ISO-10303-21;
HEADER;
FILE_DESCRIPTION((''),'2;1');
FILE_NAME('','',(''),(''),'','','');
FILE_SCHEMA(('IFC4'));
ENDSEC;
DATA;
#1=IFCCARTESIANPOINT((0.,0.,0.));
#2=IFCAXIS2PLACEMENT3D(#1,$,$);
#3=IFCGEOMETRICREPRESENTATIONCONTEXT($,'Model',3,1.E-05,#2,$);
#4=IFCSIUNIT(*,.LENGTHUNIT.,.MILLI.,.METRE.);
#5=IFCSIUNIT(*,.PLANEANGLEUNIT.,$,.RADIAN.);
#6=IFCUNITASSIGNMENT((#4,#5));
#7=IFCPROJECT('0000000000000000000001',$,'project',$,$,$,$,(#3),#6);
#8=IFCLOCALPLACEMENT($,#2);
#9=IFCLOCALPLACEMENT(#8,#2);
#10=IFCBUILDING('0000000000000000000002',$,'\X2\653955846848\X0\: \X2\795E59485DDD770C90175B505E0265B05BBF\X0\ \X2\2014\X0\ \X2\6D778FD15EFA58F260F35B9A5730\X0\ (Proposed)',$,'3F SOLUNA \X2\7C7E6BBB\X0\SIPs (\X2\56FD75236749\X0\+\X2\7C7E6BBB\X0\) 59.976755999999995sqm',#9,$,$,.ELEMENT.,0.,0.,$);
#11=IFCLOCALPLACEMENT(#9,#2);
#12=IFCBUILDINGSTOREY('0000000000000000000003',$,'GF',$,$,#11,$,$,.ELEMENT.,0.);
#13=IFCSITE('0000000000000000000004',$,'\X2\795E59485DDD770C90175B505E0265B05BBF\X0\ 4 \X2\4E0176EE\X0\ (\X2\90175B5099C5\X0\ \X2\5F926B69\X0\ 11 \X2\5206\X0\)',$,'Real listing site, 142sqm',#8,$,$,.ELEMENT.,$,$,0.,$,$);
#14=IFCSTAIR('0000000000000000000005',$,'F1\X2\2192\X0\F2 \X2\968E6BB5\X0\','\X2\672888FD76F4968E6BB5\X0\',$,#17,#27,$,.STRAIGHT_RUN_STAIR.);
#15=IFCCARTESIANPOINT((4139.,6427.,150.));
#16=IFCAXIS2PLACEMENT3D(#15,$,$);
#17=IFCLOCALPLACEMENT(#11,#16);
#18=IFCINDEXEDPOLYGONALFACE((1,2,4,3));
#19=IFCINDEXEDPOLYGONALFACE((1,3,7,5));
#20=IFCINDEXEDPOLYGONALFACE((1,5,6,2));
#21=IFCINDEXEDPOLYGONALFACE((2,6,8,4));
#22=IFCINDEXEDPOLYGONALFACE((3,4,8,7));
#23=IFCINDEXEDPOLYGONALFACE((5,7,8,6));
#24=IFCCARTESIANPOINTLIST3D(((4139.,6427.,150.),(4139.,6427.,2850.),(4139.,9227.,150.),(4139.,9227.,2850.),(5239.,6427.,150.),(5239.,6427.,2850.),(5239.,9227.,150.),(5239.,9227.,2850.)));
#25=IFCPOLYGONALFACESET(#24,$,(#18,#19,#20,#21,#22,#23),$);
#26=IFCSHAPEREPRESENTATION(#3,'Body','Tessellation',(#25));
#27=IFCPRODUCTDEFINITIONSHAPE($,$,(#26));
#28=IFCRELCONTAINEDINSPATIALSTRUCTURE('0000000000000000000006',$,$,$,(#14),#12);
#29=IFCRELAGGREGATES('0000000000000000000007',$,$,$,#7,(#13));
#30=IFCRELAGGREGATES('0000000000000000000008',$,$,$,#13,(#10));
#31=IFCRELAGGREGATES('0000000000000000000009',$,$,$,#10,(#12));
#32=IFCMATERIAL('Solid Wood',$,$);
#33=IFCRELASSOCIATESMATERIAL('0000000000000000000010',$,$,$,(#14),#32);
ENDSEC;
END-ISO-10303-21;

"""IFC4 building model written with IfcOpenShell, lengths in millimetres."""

from ifc_helpers import new_model, si_unit, frame, frame_2d, origin, place, context, project, spatial, rectangle, extrude, material, element, save


model = new_model("IFC4")

# Units and contexts
model_context = context("Model", 3, precision=1e-05, world=origin())
ifc_project = project(units=[si_unit("LENGTHUNIT", "METRE", prefix="MILLI"), si_unit("PLANEANGLEUNIT", "RADIAN")], contexts=[model_context])

# Site, building, storey
site_placement = place(None, origin())
site = spatial("IfcSite", under=ifc_project, at=site_placement, Name="神奈川県逗子市新宿 4 丁目 (逗子駅 徒歩 11 分)", ObjectType="Real listing site, 142sqm", CompositionType="ELEMENT", RefElevation=0.0)
building_placement = place(site_placement, origin())
building = spatial("IfcBuilding", under=site, at=building_placement, Name="改善案: 神奈川県逗子市新宿 — 海近建売想定地 (Proposed)", ObjectType="3F SOLUNA 籾殻SIPs (国産杉+籾殻) 59.976755999999995sqm", CompositionType="ELEMENT", ElevationOfRefHeight=0.0, ElevationOfTerrain=0.0)
storey_placement = place(building_placement, origin())
storey = spatial("IfcBuildingStorey", under=building, at=storey_placement, Name="GF", CompositionType="ELEMENT", Elevation=0.0)

# Shared definitions
ifc_material_1 = material(Name="Solid Wood")

# Stair
stair_placement = place(storey_placement, frame((4139.0, 6427.0, 150.0)))
element("IfcStair", 1, at=stair_placement, inside=storey, material=ifc_material_1, Name="F1→F2 階段", Description="木製直階段", PredefinedType="STRAIGHT_RUN_STAIR", context=model_context, shape_type="SweptSolid", body=[
    extrude(rectangle(XDim=1100.0, YDim=2800.0, at=frame_2d((550.0, 1400.0))), frame((4139.0, 6427.0, 150.0)), (0.0, 0.0, 1.0), 2700.0),
])

save(model, "model.ifc")
